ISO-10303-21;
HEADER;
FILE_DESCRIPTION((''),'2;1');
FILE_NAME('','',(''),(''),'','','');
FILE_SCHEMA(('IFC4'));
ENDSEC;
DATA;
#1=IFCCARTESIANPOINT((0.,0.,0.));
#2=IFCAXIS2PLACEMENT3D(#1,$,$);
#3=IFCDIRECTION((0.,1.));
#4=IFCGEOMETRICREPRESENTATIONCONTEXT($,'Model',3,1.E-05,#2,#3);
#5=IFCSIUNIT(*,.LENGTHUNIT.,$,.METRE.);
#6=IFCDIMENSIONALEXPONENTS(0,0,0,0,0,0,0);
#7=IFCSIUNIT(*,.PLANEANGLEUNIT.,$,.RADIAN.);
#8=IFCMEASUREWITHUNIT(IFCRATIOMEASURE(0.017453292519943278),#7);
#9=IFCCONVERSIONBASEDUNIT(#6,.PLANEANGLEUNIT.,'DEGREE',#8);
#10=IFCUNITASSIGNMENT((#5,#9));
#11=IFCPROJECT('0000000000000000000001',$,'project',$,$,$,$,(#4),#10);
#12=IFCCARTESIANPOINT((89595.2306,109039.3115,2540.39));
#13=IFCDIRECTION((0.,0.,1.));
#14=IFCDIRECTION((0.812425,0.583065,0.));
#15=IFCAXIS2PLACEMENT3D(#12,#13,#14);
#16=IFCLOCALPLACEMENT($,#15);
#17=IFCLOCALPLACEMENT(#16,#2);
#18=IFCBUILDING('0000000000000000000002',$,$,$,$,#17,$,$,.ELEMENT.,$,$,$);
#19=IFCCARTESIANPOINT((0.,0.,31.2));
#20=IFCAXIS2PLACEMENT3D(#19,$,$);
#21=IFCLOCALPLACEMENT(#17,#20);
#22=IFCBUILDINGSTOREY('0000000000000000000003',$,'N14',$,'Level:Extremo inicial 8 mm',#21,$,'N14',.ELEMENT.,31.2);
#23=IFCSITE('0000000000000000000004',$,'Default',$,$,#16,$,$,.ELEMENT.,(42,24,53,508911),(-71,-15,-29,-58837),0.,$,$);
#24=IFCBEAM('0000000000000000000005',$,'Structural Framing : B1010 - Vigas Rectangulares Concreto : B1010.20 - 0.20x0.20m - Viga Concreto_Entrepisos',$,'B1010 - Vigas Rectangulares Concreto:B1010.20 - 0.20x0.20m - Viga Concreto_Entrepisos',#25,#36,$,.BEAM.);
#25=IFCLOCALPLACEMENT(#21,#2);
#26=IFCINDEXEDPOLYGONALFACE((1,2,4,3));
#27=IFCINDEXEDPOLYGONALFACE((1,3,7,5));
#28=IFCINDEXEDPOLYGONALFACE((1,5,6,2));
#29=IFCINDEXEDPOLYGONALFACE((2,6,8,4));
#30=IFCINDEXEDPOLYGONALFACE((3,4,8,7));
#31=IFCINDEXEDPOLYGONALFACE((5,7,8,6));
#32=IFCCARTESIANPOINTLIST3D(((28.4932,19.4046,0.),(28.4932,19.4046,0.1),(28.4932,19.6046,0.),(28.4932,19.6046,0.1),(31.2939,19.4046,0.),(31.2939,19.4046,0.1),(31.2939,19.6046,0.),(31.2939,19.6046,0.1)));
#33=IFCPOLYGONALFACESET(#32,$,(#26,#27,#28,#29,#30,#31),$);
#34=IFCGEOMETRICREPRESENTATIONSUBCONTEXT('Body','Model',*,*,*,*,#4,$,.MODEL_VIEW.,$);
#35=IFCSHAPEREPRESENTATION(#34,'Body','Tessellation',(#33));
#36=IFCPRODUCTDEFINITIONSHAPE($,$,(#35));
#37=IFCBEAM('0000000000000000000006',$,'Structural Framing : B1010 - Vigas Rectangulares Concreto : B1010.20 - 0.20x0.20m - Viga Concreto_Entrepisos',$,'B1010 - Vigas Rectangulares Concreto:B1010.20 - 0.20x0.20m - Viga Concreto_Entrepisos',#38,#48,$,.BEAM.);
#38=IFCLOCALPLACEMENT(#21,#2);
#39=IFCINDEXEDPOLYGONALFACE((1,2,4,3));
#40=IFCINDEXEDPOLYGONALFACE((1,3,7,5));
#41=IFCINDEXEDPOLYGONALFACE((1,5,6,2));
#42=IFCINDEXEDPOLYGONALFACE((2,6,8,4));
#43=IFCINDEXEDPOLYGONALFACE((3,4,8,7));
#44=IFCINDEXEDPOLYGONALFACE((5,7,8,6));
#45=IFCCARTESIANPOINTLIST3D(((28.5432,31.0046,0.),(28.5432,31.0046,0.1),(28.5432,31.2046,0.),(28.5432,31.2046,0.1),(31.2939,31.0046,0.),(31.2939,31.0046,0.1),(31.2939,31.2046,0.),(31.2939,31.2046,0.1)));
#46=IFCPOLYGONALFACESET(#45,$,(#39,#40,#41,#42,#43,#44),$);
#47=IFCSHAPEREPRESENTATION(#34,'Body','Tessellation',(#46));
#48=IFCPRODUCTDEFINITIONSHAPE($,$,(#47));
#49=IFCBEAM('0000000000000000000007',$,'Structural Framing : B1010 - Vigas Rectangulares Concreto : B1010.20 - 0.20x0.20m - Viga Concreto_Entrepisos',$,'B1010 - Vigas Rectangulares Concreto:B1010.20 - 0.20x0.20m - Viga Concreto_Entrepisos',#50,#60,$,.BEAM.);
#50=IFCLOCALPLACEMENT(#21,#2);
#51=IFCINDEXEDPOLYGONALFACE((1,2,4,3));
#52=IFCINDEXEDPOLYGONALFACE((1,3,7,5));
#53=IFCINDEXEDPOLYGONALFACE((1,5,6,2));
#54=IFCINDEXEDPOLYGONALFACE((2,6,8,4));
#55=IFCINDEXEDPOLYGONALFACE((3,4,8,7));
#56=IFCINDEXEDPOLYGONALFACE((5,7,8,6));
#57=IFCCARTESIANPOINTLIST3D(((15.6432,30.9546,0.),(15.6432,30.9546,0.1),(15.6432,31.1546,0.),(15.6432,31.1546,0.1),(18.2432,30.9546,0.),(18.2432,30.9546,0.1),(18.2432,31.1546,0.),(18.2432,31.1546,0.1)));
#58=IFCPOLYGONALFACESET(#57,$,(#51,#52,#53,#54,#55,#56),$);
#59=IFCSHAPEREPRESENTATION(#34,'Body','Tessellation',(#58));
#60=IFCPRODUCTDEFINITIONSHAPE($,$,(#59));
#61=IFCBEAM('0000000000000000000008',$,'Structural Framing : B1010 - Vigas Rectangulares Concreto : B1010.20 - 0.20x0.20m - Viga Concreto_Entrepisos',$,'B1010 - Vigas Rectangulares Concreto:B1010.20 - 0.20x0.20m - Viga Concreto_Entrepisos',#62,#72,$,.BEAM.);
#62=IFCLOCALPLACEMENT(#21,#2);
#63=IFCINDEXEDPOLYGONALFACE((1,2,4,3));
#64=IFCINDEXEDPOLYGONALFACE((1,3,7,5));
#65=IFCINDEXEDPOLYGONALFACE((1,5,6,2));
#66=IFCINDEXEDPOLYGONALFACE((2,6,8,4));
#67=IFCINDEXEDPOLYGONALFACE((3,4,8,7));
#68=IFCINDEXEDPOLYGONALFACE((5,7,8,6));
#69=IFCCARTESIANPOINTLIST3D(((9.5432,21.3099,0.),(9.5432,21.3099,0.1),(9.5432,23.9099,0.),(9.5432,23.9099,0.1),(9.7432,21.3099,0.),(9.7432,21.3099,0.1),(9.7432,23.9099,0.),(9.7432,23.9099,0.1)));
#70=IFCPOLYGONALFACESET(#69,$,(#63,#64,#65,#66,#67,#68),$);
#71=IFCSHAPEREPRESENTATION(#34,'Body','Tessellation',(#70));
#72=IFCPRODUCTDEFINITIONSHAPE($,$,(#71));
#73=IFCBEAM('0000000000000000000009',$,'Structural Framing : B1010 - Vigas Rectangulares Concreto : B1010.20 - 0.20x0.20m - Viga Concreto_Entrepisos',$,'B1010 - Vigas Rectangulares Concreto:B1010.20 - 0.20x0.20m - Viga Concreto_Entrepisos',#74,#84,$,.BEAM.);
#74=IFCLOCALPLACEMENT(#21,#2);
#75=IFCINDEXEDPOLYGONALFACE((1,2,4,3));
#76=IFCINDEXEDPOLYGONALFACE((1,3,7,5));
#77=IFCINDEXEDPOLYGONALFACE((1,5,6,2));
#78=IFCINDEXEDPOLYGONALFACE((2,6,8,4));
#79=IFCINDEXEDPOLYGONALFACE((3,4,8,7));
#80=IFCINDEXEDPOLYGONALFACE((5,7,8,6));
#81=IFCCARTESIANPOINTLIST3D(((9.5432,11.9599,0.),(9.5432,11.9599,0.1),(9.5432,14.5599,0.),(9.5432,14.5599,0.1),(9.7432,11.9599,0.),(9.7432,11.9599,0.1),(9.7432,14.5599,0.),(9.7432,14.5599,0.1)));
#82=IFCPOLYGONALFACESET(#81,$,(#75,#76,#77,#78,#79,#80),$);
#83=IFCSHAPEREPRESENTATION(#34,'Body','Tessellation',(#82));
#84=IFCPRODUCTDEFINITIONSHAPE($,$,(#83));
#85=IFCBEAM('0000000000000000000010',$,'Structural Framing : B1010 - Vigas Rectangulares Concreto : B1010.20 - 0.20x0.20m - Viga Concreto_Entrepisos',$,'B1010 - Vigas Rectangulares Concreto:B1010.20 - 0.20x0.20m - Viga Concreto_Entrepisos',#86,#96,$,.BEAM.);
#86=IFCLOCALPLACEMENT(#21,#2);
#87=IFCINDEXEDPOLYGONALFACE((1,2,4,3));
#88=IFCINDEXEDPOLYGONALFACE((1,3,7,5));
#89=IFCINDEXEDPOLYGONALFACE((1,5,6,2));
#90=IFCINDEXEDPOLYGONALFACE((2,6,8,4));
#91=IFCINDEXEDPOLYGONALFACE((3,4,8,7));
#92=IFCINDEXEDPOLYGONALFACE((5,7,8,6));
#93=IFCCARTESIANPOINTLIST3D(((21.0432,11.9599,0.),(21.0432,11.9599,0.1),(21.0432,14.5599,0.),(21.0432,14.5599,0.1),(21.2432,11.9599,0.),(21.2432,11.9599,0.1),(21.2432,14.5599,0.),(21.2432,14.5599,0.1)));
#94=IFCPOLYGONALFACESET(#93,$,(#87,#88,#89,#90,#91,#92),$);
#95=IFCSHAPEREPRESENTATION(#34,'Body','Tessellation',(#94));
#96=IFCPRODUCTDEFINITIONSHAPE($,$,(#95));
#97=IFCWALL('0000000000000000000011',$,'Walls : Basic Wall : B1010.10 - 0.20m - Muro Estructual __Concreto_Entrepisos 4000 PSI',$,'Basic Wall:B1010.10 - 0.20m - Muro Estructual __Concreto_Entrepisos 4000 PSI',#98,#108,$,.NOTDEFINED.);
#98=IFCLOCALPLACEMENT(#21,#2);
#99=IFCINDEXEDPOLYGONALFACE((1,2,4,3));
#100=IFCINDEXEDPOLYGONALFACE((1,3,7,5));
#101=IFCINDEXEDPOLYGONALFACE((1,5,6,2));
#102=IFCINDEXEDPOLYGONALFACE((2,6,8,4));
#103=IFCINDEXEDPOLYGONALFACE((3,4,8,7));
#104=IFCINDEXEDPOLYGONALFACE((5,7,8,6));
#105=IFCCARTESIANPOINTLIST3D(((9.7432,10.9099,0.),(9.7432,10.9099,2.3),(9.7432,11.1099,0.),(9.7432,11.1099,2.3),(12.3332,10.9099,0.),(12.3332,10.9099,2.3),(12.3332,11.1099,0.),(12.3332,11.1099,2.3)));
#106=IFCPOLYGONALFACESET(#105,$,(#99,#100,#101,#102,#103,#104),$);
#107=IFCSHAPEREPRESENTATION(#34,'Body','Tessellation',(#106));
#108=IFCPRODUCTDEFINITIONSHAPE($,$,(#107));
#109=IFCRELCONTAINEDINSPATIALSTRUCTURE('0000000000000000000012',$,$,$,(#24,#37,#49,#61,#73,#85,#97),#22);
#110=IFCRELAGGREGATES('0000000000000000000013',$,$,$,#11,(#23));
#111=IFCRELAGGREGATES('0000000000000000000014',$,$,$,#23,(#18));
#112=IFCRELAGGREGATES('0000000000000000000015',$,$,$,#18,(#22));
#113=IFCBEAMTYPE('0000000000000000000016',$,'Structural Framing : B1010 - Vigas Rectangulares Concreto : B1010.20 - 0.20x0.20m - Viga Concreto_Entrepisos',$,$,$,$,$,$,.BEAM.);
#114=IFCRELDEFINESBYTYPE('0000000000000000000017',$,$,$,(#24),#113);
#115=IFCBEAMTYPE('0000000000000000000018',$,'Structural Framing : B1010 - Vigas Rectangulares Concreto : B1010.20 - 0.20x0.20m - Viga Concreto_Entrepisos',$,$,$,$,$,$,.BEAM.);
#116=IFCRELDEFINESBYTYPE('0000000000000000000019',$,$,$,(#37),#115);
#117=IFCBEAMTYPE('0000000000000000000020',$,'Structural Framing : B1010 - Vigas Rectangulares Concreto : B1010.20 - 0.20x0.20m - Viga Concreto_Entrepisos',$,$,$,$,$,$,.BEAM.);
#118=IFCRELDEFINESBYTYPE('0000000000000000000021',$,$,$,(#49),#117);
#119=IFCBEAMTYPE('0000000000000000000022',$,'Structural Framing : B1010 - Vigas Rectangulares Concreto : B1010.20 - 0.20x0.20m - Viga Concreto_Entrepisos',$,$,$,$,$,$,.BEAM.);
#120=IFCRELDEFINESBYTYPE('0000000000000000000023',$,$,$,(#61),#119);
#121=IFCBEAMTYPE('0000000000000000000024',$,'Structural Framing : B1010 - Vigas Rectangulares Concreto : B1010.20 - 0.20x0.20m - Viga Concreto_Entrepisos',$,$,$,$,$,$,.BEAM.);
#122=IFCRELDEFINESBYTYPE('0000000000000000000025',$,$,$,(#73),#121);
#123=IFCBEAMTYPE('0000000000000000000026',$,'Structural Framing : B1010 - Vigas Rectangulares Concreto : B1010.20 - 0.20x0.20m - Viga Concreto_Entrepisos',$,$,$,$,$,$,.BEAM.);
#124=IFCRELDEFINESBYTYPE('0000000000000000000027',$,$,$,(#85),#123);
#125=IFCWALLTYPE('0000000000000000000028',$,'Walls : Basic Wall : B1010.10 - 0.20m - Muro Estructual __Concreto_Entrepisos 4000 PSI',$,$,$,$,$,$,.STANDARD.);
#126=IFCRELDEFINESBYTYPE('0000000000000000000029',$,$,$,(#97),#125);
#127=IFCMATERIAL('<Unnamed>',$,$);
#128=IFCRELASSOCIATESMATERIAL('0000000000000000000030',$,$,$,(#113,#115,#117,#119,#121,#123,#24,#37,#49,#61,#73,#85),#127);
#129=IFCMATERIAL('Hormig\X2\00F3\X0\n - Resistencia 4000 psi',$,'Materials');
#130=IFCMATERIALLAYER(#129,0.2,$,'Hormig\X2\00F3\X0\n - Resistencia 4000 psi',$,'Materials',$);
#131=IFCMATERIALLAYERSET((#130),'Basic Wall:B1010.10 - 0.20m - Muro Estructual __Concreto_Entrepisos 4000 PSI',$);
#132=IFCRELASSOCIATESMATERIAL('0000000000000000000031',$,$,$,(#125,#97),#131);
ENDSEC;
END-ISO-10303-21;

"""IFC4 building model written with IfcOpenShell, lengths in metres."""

from ifc_helpers import new_model, entity, si_unit, converted_unit, direction, frame, frame_2d, origin, place, context, subcontext, project, spatial, polyline, segment, composite_curve, rectangle, outline, extrude, source, transform, mapped, material, layer, layer_set, layer_usage, material_profile, profile_set, profile_usage, type_object, type_shapes, element, save


model = new_model("IFC4")

# Units and contexts
model_context = context("Model", 3, precision=1e-05, world=origin(), true_north=direction((0.0, 1.0)))
body_context = subcontext(model_context, "Body", "Model", "MODEL_VIEW")
ifc_project = project(units=[si_unit("LENGTHUNIT", "METRE"), converted_unit("PLANEANGLEUNIT", "DEGREE", entity("IfcRatioMeasure", 0.017453292519943278), si_unit("PLANEANGLEUNIT", "RADIAN"), dimensions=[0, 0, 0, 0, 0, 0, 0])], contexts=[model_context])

# Site, building, storey
site_placement = place(None, frame((89595.2306, 109039.3115, 2540.39), z_axis=(0.0, 0.0, 1.0), x_axis=(0.812425, 0.583065, 0.0)))
site = spatial("IfcSite", under=ifc_project, at=site_placement, Name="Default", CompositionType="ELEMENT", RefLatitude=(42, 24, 53, 508911), RefLongitude=(-71, -15, -29, -58837), RefElevation=0.0)
building_placement = place(site_placement, origin())
building = spatial("IfcBuilding", under=site, at=building_placement, CompositionType="ELEMENT")
storey_placement = place(building_placement, frame((0.0, 0.0, 31.2)))
storey = spatial("IfcBuildingStorey", under=building, at=storey_placement, Name="N14", ObjectType="Level:Extremo inicial 8 mm", LongName="N14", CompositionType="ELEMENT", Elevation=31.2)

# Beams
ifc_material_1 = material(Name="<Unnamed>")
ifc_material_profile_1 = material_profile(ifc_material_1, outline(composite_curve([segment(polyline([(-0.1, 0.0, 0.0), (-0.1, 0.1, 0.0)]), True, "CONTINUOUS"), segment(polyline([(-0.1, 0.1, 0.0), (0.1, 0.1, 0.0)]), True, "CONTINUOUS"), segment(polyline([(0.1, 0.1, 0.0), (0.1, 0.0, 0.0)]), True, "CONTINUOUS"), segment(polyline([(0.1, 0.0, 0.0), (-0.1, 0.0, 0.0)]), True, "CONTINUOUS")], self_intersect=False), kind="CURVE"), Name="B1010.20 - 0.20x0.20m - Viga Concreto_Entrepisos")
ifc_material_profile_2 = material_profile(ifc_material_1, outline(composite_curve([segment(polyline([(-1.4004, -0.1, 0.1), (-1.4004, 0.1, 0.1)]), True, "CONTINUOUS"), segment(polyline([(-1.4004, 0.1, 0.1), (-1.4004, 0.1, -0.1)]), True, "CONTINUOUS"), segment(polyline([(-1.4004, 0.1, -0.1), (-1.4004, -0.1, -0.1)]), True, "CONTINUOUS"), segment(polyline([(-1.4004, -0.1, -0.1), (-1.4004, -0.1, 0.1)]), True, "CONTINUOUS")], self_intersect=False), kind="CURVE"), Name="B1010.20 - 0.20x0.20m - Viga Concreto_Entrepisos")
ifc_profile_set_1 = profile_set([ifc_material_profile_1, ifc_material_profile_2], Name="B1010.20 - 0.20x0.20m - Viga Concreto_Entrepisos")
ifc_profile_usage_1 = profile_usage(ifc_profile_set_1, cardinal=8)
beam_type_1 = type_object("IfcBeamType", Name="Structural Framing : B1010 - Vigas Rectangulares Concreto : B1010.20 - 0.20x0.20m - Viga Concreto_Entrepisos", PredefinedType="BEAM", material=ifc_profile_set_1)
shared_shape_1 = source(origin(), body_context, "Body", "SweptSolid", [
    extrude(rectangle(XDim=0.1, YDim=0.2, at=frame_2d((0.0, 0.0), x_axis=(1.0, 0.0))), frame((31.2939, 19.5046, 31.25), z_axis=(-1.0, 0.0, 0.0), x_axis=(0.0, 0.0, -1.0)), (0.0, 0.0, 1.0), 2.8007),
])
type_shapes(beam_type_1, [shared_shape_1])
beam_1_placement = place(storey_placement, frame((0.0, 0.0, -31.2)))
element("IfcBeam", 1, at=beam_1_placement, inside=storey, type_object=beam_type_1, material=ifc_profile_usage_1, Name="Structural Framing : B1010 - Vigas Rectangulares Concreto : B1010.20 - 0.20x0.20m - Viga Concreto_Entrepisos", ObjectType="B1010 - Vigas Rectangulares Concreto:B1010.20 - 0.20x0.20m - Viga Concreto_Entrepisos", PredefinedType="BEAM", context=body_context, shape_type="MappedRepresentation", body=[
    mapped(shared_shape_1, transform((0.0, 0.0, 0.0), scale=1.0)),
])
ifc_profile_usage_2 = profile_usage(ifc_profile_set_1, cardinal=8)
beam_type_2 = type_object("IfcBeamType", Name="Structural Framing : B1010 - Vigas Rectangulares Concreto : B1010.20 - 0.20x0.20m - Viga Concreto_Entrepisos", PredefinedType="BEAM", material=ifc_profile_set_1)
shared_shape_2 = source(origin(), body_context, "Body", "SweptSolid", [
    extrude(rectangle(XDim=0.1, YDim=0.2, at=frame_2d((0.0, 0.0), x_axis=(1.0, 0.0))), frame((31.2939, 31.1046, 31.25), z_axis=(-1.0, 0.0, 0.0), x_axis=(0.0, 0.0, -1.0)), (0.0, 0.0, 1.0), 2.7507),
])
type_shapes(beam_type_2, [shared_shape_2])
beam_2_placement = place(storey_placement, frame((0.0, 0.0, -31.2)))
element("IfcBeam", 2, at=beam_2_placement, inside=storey, type_object=beam_type_2, material=ifc_profile_usage_2, Name="Structural Framing : B1010 - Vigas Rectangulares Concreto : B1010.20 - 0.20x0.20m - Viga Concreto_Entrepisos", ObjectType="B1010 - Vigas Rectangulares Concreto:B1010.20 - 0.20x0.20m - Viga Concreto_Entrepisos", PredefinedType="BEAM", context=body_context, shape_type="MappedRepresentation", body=[
    mapped(shared_shape_2, transform((0.0, 0.0, 0.0), scale=1.0)),
])
ifc_profile_usage_3 = profile_usage(ifc_profile_set_1, cardinal=8)
beam_type_3 = type_object("IfcBeamType", Name="Structural Framing : B1010 - Vigas Rectangulares Concreto : B1010.20 - 0.20x0.20m - Viga Concreto_Entrepisos", PredefinedType="BEAM", material=ifc_profile_set_1)
shared_shape_3 = source(origin(), body_context, "Body", "SweptSolid", [
    extrude(rectangle(XDim=0.1, YDim=0.2, at=frame_2d((0.0, 0.0), x_axis=(1.0, 0.0))), frame((18.2432, 31.0546, 31.25), z_axis=(-1.0, 0.0, 0.0), x_axis=(0.0, 0.0, -1.0)), (0.0, 0.0, 1.0), 2.6),
])
type_shapes(beam_type_3, [shared_shape_3])
beam_3_placement = place(storey_placement, frame((0.0, 0.0, -31.2)))
element("IfcBeam", 3, at=beam_3_placement, inside=storey, type_object=beam_type_3, material=ifc_profile_usage_3, Name="Structural Framing : B1010 - Vigas Rectangulares Concreto : B1010.20 - 0.20x0.20m - Viga Concreto_Entrepisos", ObjectType="B1010 - Vigas Rectangulares Concreto:B1010.20 - 0.20x0.20m - Viga Concreto_Entrepisos", PredefinedType="BEAM", context=body_context, shape_type="MappedRepresentation", body=[
    mapped(shared_shape_3, transform((0.0, 0.0, 0.0), scale=1.0)),
])
ifc_profile_usage_4 = profile_usage(ifc_profile_set_1, cardinal=8)
beam_type_4 = type_object("IfcBeamType", Name="Structural Framing : B1010 - Vigas Rectangulares Concreto : B1010.20 - 0.20x0.20m - Viga Concreto_Entrepisos", PredefinedType="BEAM", material=ifc_profile_set_1)
shared_shape_4 = source(origin(), body_context, "Body", "SweptSolid", [
    extrude(rectangle(XDim=0.1, YDim=0.2, at=frame_2d((0.0, 0.0), x_axis=(0.0, 1.0))), frame((9.6432, 21.3099, 31.25), z_axis=(0.0, 1.0, 0.0), x_axis=(-1.0, 0.0, 0.0)), (0.0, 0.0, 1.0), 2.6),
])
type_shapes(beam_type_4, [shared_shape_4])
beam_4_placement = place(storey_placement, frame((0.0, 0.0, -31.2)))
element("IfcBeam", 4, at=beam_4_placement, inside=storey, type_object=beam_type_4, material=ifc_profile_usage_4, Name="Structural Framing : B1010 - Vigas Rectangulares Concreto : B1010.20 - 0.20x0.20m - Viga Concreto_Entrepisos", ObjectType="B1010 - Vigas Rectangulares Concreto:B1010.20 - 0.20x0.20m - Viga Concreto_Entrepisos", PredefinedType="BEAM", context=body_context, shape_type="MappedRepresentation", body=[
    mapped(shared_shape_4, transform((0.0, 0.0, 0.0), scale=1.0)),
])
ifc_profile_usage_5 = profile_usage(ifc_profile_set_1, cardinal=8)
beam_type_5 = type_object("IfcBeamType", Name="Structural Framing : B1010 - Vigas Rectangulares Concreto : B1010.20 - 0.20x0.20m - Viga Concreto_Entrepisos", PredefinedType="BEAM", material=ifc_profile_set_1)
shared_shape_5 = source(origin(), body_context, "Body", "SweptSolid", [
    extrude(rectangle(XDim=0.1, YDim=0.2, at=frame_2d((0.0, 0.0), x_axis=(0.0, 1.0))), frame((9.6432, 11.9599, 31.25), z_axis=(0.0, 1.0, 0.0), x_axis=(-1.0, 0.0, 0.0)), (0.0, 0.0, 1.0), 2.6),
])
type_shapes(beam_type_5, [shared_shape_5])
beam_5_placement = place(storey_placement, frame((0.0, 0.0, -31.2)))
element("IfcBeam", 5, at=beam_5_placement, inside=storey, type_object=beam_type_5, material=ifc_profile_usage_5, Name="Structural Framing : B1010 - Vigas Rectangulares Concreto : B1010.20 - 0.20x0.20m - Viga Concreto_Entrepisos", ObjectType="B1010 - Vigas Rectangulares Concreto:B1010.20 - 0.20x0.20m - Viga Concreto_Entrepisos", PredefinedType="BEAM", context=body_context, shape_type="MappedRepresentation", body=[
    mapped(shared_shape_5, transform((0.0, 0.0, 0.0), scale=1.0)),
])
ifc_profile_usage_6 = profile_usage(ifc_profile_set_1, cardinal=8)
beam_type_6 = type_object("IfcBeamType", Name="Structural Framing : B1010 - Vigas Rectangulares Concreto : B1010.20 - 0.20x0.20m - Viga Concreto_Entrepisos", PredefinedType="BEAM", material=ifc_profile_set_1)
shared_shape_6 = source(origin(), body_context, "Body", "SweptSolid", [
    extrude(rectangle(XDim=0.1, YDim=0.2, at=frame_2d((0.0, 0.0), x_axis=(0.0, 1.0))), frame((21.1432, 11.9599, 31.25), z_axis=(0.0, 1.0, 0.0), x_axis=(-1.0, 0.0, 0.0)), (0.0, 0.0, 1.0), 2.6),
])
type_shapes(beam_type_6, [shared_shape_6])
beam_6_placement = place(storey_placement, frame((0.0, 0.0, -31.2)))
element("IfcBeam", 6, at=beam_6_placement, inside=storey, type_object=beam_type_6, material=ifc_profile_usage_6, Name="Structural Framing : B1010 - Vigas Rectangulares Concreto : B1010.20 - 0.20x0.20m - Viga Concreto_Entrepisos", ObjectType="B1010 - Vigas Rectangulares Concreto:B1010.20 - 0.20x0.20m - Viga Concreto_Entrepisos", PredefinedType="BEAM", context=body_context, shape_type="MappedRepresentation", body=[
    mapped(shared_shape_6, transform((0.0, 0.0, 0.0), scale=1.0)),
])

# Wall
ifc_material_2 = material(Name="Hormigón - Resistencia 4000 psi", Category="Materials")
ifc_layer_1 = layer(ifc_material_2, 0.2, Name="Hormigón - Resistencia 4000 psi", Category="Materials")
ifc_layer_set_1 = layer_set([ifc_layer_1], Name="Basic Wall:B1010.10 - 0.20m - Muro Estructual __Concreto_Entrepisos 4000 PSI")
ifc_layer_usage_1 = layer_usage(ifc_layer_set_1, "AXIS2", "POSITIVE", -0.1)
wall_type = type_object("IfcWallType", Name="Walls : Basic Wall : B1010.10 - 0.20m - Muro Estructual __Concreto_Entrepisos 4000 PSI", PredefinedType="STANDARD", material=ifc_layer_set_1)
wall_placement = place(storey_placement, frame((9.7432, 11.0099, 0.0)))
element("IfcWall", 7, at=wall_placement, inside=storey, type_object=wall_type, material=ifc_layer_usage_1, Name="Walls : Basic Wall : B1010.10 - 0.20m - Muro Estructual __Concreto_Entrepisos 4000 PSI", ObjectType="Basic Wall:B1010.10 - 0.20m - Muro Estructual __Concreto_Entrepisos 4000 PSI", PredefinedType="NOTDEFINED", context=body_context, shape_type="SweptSolid", body=[
    extrude(rectangle(XDim=2.59, YDim=0.2, at=frame_2d((1.295, 0.0), x_axis=(-1.0, 0.0))), origin(), (0.0, 0.0, 1.0), 2.3),
])

save(model, "model.ifc")
